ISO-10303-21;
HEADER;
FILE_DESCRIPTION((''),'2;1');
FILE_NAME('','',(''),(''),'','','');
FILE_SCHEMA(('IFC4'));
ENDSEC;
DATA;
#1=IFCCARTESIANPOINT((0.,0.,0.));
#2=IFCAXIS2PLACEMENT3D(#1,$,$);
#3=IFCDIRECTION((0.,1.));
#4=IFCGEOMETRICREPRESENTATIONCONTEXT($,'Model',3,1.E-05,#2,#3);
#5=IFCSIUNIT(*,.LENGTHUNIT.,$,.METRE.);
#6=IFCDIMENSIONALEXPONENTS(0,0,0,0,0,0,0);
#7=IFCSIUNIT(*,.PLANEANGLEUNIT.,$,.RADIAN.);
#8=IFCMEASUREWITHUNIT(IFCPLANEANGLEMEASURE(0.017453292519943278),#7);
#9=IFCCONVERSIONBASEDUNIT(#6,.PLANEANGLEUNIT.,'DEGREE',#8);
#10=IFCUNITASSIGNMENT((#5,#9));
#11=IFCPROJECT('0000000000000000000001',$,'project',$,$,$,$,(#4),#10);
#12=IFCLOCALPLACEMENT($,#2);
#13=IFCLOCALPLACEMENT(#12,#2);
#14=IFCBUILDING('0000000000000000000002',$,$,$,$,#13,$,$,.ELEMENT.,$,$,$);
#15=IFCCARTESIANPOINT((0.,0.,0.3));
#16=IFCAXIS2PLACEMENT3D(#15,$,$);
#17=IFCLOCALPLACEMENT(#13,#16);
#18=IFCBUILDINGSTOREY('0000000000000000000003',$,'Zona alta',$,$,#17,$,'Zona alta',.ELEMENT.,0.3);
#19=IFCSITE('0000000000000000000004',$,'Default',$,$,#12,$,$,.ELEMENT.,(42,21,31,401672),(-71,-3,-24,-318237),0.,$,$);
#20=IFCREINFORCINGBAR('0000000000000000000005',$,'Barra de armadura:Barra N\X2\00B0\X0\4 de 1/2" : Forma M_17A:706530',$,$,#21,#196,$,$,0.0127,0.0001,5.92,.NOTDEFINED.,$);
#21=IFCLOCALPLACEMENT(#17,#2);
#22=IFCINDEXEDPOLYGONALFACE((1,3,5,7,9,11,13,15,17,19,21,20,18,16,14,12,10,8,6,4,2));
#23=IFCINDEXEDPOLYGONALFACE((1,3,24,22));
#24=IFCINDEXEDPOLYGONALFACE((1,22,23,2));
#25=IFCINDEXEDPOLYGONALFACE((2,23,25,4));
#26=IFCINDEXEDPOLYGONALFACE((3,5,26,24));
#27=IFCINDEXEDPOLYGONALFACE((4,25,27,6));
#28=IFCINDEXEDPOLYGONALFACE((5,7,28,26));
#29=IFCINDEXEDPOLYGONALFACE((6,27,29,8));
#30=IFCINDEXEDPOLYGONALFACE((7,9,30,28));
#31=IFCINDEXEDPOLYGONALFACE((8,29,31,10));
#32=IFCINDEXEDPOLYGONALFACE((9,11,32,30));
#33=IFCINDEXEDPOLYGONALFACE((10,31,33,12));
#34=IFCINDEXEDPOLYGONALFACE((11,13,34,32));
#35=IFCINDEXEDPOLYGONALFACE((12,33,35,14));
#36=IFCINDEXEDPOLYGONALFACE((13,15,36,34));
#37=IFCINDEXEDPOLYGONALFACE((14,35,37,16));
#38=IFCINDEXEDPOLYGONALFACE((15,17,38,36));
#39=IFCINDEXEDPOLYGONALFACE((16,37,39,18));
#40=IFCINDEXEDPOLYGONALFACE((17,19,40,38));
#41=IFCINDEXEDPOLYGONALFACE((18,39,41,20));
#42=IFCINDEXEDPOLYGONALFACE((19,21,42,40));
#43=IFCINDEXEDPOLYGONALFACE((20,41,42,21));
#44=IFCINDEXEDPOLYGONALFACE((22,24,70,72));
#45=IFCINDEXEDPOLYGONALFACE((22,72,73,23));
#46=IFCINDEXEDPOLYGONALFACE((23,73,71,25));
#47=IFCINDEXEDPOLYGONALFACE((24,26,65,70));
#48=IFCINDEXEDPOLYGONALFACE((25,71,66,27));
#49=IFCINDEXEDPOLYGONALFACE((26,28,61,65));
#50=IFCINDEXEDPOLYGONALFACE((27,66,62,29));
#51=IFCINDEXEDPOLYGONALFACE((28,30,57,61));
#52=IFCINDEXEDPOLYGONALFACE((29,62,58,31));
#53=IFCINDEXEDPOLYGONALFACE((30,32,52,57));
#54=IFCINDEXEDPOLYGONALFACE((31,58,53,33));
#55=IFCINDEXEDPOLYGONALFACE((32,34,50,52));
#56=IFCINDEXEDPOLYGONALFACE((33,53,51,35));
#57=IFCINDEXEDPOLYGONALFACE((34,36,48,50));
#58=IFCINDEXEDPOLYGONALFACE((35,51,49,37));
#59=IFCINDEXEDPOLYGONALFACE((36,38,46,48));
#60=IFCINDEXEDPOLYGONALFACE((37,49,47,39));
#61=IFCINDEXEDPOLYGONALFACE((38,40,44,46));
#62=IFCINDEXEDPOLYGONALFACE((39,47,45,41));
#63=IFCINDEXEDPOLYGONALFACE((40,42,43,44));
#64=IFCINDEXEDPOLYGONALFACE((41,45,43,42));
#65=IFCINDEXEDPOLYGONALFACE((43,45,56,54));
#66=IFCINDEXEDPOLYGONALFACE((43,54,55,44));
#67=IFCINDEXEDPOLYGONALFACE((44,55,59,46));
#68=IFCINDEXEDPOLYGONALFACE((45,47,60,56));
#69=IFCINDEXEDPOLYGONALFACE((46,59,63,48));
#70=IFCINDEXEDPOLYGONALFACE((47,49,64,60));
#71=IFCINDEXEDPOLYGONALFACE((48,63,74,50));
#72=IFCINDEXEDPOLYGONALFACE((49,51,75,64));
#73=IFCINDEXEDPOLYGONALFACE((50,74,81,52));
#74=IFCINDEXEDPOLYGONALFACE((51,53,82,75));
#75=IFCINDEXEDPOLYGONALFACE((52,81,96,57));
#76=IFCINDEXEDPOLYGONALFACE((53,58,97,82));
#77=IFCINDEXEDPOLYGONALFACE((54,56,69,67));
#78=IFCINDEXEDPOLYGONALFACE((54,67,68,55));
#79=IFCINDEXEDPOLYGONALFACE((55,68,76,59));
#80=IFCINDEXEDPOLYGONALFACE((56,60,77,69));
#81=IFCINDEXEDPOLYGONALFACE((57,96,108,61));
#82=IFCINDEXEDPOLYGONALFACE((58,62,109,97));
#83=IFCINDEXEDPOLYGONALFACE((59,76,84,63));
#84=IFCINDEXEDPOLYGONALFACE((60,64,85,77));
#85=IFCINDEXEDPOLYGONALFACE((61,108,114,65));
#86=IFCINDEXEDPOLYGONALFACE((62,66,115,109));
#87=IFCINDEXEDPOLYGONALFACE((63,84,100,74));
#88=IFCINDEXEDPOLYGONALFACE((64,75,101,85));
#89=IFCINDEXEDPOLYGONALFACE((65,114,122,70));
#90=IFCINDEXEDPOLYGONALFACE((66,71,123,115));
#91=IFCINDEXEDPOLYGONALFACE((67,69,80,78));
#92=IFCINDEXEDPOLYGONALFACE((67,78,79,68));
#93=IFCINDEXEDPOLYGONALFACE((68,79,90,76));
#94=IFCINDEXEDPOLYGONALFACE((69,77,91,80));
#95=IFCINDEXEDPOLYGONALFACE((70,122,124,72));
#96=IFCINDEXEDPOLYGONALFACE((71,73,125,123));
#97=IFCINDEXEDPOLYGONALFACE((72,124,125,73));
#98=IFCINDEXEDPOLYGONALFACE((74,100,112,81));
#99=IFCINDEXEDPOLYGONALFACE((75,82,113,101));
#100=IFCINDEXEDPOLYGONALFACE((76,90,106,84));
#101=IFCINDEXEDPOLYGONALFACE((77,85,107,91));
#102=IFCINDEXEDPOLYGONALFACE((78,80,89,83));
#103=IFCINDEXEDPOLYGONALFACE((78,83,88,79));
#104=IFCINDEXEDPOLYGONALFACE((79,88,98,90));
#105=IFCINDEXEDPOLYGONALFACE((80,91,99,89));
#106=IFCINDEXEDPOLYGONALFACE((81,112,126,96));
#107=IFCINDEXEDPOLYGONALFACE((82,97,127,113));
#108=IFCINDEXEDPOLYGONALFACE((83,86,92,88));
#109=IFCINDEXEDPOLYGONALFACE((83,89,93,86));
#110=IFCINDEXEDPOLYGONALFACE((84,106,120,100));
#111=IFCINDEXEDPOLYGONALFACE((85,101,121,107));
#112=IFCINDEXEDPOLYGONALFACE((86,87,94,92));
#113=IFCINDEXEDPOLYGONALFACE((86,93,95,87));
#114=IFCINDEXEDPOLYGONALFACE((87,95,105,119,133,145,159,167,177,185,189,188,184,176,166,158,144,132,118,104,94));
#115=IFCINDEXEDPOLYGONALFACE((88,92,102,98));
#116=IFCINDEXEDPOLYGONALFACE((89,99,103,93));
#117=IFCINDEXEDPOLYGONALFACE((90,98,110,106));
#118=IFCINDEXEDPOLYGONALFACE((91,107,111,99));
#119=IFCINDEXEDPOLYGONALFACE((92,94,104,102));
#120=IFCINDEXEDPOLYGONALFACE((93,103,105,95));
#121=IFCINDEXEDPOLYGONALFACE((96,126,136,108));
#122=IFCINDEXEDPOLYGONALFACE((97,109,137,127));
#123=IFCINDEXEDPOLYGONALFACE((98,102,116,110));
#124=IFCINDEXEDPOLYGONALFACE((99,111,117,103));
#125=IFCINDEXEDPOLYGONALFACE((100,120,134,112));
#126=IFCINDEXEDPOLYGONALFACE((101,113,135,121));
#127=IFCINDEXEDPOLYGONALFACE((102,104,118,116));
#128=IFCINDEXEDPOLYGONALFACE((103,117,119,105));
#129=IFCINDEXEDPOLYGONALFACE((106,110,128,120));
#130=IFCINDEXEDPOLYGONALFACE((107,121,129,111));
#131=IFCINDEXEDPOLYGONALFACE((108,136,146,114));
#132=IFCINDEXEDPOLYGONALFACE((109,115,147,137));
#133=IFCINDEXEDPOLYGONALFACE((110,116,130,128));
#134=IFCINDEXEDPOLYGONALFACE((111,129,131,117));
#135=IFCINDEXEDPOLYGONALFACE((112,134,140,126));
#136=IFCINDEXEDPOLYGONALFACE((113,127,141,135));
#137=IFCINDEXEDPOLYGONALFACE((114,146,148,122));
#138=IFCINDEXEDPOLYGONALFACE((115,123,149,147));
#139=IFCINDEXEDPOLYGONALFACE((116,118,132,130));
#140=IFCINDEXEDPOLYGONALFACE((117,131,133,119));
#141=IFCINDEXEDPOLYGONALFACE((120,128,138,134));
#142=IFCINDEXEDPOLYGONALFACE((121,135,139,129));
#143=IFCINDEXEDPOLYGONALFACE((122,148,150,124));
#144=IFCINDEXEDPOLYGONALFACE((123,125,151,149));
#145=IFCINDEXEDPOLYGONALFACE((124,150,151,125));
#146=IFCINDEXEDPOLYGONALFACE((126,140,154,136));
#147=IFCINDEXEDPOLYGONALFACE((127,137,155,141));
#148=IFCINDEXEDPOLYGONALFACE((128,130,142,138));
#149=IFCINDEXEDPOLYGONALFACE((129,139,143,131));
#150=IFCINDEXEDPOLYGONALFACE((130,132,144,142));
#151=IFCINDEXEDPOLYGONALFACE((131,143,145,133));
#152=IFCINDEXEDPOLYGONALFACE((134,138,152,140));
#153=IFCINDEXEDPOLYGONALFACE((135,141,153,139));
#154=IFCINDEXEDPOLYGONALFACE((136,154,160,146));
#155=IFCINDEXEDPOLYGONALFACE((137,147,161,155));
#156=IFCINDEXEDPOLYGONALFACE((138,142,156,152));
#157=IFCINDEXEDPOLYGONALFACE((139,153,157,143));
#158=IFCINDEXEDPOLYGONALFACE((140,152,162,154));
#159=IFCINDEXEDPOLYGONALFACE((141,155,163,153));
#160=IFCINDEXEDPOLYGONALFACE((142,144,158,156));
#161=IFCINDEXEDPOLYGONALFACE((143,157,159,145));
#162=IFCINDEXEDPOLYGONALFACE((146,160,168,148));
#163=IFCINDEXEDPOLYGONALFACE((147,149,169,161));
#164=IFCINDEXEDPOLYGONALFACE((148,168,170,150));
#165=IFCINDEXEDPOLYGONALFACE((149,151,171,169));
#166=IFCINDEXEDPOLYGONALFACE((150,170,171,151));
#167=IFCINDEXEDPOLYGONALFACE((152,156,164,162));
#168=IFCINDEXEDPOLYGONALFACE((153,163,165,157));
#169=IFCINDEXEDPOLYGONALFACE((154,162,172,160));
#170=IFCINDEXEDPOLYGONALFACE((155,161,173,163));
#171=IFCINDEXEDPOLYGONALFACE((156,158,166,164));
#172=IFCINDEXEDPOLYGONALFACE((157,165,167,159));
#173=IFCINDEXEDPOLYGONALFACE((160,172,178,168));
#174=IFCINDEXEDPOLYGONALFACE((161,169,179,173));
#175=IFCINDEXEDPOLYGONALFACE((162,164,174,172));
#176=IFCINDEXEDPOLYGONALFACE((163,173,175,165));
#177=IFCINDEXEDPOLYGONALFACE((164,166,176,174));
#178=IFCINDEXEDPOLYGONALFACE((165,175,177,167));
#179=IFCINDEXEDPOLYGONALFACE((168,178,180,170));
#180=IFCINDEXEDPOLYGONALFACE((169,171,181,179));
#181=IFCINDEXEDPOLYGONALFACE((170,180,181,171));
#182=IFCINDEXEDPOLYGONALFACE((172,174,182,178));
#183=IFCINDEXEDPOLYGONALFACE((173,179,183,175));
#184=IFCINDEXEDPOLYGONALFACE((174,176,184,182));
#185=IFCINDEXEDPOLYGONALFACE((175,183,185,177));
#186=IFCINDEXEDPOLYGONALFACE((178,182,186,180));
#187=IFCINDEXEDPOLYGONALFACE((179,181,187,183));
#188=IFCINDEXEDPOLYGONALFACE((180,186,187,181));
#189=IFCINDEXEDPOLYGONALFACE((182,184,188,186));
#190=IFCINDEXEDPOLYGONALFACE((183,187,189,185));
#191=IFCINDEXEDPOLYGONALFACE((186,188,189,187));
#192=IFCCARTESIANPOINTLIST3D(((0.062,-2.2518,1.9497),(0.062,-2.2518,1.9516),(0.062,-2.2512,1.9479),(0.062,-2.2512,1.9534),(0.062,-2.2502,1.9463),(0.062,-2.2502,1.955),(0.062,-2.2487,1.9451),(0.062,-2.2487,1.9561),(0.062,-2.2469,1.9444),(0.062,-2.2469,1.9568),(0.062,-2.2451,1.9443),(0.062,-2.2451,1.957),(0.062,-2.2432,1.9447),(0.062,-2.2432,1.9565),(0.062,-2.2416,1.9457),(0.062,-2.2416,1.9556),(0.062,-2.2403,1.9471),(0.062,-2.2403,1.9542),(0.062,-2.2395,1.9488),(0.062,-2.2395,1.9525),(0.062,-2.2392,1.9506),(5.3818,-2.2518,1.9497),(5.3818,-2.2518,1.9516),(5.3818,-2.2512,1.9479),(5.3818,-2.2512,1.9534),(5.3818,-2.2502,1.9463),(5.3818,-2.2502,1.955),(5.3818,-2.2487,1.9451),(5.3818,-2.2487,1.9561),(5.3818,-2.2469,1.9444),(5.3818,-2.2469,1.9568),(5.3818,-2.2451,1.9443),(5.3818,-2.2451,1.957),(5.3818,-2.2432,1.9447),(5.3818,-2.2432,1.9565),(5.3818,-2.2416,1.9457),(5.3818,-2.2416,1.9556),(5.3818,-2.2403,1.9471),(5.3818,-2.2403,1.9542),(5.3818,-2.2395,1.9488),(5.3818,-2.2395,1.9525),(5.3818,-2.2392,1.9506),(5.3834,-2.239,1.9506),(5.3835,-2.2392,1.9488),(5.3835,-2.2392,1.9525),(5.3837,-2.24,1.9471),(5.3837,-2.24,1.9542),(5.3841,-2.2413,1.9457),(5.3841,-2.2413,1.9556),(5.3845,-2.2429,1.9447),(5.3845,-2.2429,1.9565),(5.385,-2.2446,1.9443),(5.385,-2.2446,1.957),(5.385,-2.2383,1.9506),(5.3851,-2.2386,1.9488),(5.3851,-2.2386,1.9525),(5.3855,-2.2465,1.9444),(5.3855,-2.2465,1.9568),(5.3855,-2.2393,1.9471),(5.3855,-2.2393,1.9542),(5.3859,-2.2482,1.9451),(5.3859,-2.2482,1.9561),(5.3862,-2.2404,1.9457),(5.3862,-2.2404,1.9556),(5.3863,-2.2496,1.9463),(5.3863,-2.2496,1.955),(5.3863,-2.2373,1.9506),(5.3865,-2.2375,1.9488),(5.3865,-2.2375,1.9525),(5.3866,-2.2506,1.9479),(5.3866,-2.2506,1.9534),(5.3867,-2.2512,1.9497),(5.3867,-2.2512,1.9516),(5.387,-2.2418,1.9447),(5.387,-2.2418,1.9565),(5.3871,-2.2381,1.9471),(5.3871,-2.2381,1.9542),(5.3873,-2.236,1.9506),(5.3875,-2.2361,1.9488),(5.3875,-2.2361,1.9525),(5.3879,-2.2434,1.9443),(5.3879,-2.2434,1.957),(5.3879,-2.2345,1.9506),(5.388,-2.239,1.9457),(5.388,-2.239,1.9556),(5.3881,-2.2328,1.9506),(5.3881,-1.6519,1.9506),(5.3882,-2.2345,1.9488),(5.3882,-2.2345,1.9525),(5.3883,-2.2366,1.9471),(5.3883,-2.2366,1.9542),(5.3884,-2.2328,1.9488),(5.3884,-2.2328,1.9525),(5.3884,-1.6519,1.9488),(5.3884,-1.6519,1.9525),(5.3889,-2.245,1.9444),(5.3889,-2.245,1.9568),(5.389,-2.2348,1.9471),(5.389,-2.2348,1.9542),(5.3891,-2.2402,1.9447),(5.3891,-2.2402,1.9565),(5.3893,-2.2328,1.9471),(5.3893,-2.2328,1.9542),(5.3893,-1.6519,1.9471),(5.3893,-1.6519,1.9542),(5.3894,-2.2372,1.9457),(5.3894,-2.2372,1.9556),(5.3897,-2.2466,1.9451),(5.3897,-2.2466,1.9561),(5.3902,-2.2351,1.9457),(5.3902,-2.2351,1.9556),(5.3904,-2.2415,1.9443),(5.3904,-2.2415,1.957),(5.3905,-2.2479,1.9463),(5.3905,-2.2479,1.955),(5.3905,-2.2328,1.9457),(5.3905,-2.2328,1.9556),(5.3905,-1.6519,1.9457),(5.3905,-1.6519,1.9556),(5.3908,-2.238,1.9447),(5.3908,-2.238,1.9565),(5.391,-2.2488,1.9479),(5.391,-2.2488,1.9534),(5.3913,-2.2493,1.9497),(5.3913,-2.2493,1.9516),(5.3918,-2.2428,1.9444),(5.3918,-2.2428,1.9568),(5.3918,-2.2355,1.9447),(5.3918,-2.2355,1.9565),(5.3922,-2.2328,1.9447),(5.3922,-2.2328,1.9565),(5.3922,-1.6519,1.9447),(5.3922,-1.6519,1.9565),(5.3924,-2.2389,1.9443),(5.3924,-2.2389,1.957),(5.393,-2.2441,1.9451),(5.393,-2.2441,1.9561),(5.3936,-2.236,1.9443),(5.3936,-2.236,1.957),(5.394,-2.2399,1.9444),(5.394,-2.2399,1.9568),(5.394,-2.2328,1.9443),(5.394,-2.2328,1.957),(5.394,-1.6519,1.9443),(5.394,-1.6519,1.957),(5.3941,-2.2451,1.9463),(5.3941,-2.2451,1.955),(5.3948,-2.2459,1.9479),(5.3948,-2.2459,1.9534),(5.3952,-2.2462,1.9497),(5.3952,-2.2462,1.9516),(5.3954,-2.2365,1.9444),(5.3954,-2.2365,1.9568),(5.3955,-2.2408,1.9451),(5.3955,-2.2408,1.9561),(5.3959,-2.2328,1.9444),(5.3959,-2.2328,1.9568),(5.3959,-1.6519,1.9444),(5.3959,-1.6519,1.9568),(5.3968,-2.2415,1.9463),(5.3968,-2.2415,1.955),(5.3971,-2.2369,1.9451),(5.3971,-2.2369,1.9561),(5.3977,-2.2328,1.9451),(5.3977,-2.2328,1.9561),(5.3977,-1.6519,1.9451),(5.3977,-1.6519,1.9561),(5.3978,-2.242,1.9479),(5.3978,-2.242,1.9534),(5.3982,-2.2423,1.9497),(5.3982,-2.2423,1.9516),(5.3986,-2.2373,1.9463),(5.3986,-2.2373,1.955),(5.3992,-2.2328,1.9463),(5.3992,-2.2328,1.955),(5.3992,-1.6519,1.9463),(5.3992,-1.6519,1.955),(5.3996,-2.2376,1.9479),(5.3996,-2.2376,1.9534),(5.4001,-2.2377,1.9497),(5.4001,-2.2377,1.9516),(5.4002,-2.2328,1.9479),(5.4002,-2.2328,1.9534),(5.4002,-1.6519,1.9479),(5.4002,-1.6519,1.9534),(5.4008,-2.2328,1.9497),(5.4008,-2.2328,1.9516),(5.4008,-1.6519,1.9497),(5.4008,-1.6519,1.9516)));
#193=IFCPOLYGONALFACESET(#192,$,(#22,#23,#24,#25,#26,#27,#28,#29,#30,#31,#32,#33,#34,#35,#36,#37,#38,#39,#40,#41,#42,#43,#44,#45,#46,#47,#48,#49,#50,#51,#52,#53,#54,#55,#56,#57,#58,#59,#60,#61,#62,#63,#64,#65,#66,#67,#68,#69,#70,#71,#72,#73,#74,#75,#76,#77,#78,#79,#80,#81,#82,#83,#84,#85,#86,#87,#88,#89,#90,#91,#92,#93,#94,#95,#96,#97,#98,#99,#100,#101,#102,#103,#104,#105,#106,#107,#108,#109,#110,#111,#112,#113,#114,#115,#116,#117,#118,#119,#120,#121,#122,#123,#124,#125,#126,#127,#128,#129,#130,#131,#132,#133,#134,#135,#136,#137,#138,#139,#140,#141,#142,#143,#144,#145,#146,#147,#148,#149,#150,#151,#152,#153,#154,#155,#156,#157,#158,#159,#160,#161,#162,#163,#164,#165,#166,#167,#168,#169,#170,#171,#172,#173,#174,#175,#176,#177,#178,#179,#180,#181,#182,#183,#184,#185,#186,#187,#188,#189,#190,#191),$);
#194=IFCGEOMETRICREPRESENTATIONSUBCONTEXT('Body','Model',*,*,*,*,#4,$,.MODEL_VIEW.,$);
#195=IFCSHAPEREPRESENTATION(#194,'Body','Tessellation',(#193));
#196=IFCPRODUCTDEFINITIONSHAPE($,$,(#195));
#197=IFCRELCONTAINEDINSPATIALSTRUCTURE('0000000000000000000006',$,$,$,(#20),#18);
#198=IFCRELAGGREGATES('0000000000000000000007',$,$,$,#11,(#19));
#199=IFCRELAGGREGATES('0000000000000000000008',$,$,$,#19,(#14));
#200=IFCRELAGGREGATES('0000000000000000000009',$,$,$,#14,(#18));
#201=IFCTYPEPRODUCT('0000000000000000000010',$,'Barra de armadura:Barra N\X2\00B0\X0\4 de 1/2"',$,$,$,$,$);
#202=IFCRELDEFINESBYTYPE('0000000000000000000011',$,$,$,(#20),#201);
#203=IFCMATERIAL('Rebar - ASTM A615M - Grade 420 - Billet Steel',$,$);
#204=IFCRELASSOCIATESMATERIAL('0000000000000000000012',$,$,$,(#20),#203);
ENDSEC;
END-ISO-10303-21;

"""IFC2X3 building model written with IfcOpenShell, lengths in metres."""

from ifc_helpers import new_model, entity, si_unit, converted_unit, direction, frame, origin, place, context, subcontext, project, spatial, material, type_object, element, save


model = new_model("IFC2X3")

# Units and contexts
model_context = context("Model", 3, precision=1e-05, world=origin(), true_north=direction((0.0, 1.0)))
body_context = subcontext(model_context, "Body", "Model", "MODEL_VIEW")
ifc_project = project(units=[si_unit("LENGTHUNIT", "METRE"), converted_unit("PLANEANGLEUNIT", "DEGREE", entity("IfcPlaneAngleMeasure", 0.017453292519943278), si_unit("PLANEANGLEUNIT", "RADIAN"), dimensions=[0, 0, 0, 0, 0, 0, 0])], contexts=[model_context])

# Site, building, storey
site_placement = place(None, origin())
site = spatial("IfcSite", under=ifc_project, at=site_placement, Name="Default", CompositionType="ELEMENT", RefLatitude=(42, 21, 31, 401672), RefLongitude=(-71, -3, -24, -318237), RefElevation=0.0)
building_placement = place(site_placement, origin())
building = spatial("IfcBuilding", under=site, at=building_placement, CompositionType="ELEMENT")
storey_placement = place(building_placement, frame((0.0, 0.0, 0.3)))
storey = spatial("IfcBuildingStorey", under=building, at=storey_placement, Name="Zona alta", LongName="Zona alta", CompositionType="ELEMENT", Elevation=0.3)

# Reinforcing bar
ifc_material = material(Name="Rebar - ASTM A615M - Grade 420 - Billet Steel")
type_product_1 = type_object("IfcTypeProduct", Name="Barra de armadura:Barra N°4 de 1/2\"")
reinforcing_bar_1_placement = place(storey_placement, origin())
element("IfcReinforcingBar", 1, at=reinforcing_bar_1_placement, inside=storey, type_object=type_product_1, material=ifc_material, Name="Barra de armadura:Barra N°4 de 1/2\" : Forma M_17A:706530", BarLength=5.92, BarRole="NOTDEFINED", CrossSectionArea=0.0001, NominalDiameter=0.0127, context=body_context, shape_type="AdvancedSweptSolid", body=[
    entity("IfcSweptDiskSolid", entity("IfcCompositeCurve", [entity("IfcCompositeCurveSegment", "CONTINUOUS", True, entity("IfcPolyline", [entity("IfcCartesianPoint", [0.062, -2.2455, 1.9506]), entity("IfcCartesianPoint", [5.3818, -2.2455, 1.9506])])), entity("IfcCompositeCurveSegment", "CONTINUOUS", True, entity("IfcTrimmedCurve", entity("IfcCircle", entity("IfcAxis2Placement3D", entity("IfcCartesianPoint", [5.3818, -2.2328, 1.9506])), 0.0127), [entity("IfcParameterValue", 270.0)], [entity("IfcParameterValue", 360.0)], True, "PARAMETER")), entity("IfcCompositeCurveSegment", "CONTINUOUS", True, entity("IfcPolyline", [entity("IfcCartesianPoint", [5.3945, -2.2328, 1.9506]), entity("IfcCartesianPoint", [5.3945, -1.6519, 1.9506])]))], False), 0.0063, None, 0.0, 92.0),
])

save(model, "model.ifc")
